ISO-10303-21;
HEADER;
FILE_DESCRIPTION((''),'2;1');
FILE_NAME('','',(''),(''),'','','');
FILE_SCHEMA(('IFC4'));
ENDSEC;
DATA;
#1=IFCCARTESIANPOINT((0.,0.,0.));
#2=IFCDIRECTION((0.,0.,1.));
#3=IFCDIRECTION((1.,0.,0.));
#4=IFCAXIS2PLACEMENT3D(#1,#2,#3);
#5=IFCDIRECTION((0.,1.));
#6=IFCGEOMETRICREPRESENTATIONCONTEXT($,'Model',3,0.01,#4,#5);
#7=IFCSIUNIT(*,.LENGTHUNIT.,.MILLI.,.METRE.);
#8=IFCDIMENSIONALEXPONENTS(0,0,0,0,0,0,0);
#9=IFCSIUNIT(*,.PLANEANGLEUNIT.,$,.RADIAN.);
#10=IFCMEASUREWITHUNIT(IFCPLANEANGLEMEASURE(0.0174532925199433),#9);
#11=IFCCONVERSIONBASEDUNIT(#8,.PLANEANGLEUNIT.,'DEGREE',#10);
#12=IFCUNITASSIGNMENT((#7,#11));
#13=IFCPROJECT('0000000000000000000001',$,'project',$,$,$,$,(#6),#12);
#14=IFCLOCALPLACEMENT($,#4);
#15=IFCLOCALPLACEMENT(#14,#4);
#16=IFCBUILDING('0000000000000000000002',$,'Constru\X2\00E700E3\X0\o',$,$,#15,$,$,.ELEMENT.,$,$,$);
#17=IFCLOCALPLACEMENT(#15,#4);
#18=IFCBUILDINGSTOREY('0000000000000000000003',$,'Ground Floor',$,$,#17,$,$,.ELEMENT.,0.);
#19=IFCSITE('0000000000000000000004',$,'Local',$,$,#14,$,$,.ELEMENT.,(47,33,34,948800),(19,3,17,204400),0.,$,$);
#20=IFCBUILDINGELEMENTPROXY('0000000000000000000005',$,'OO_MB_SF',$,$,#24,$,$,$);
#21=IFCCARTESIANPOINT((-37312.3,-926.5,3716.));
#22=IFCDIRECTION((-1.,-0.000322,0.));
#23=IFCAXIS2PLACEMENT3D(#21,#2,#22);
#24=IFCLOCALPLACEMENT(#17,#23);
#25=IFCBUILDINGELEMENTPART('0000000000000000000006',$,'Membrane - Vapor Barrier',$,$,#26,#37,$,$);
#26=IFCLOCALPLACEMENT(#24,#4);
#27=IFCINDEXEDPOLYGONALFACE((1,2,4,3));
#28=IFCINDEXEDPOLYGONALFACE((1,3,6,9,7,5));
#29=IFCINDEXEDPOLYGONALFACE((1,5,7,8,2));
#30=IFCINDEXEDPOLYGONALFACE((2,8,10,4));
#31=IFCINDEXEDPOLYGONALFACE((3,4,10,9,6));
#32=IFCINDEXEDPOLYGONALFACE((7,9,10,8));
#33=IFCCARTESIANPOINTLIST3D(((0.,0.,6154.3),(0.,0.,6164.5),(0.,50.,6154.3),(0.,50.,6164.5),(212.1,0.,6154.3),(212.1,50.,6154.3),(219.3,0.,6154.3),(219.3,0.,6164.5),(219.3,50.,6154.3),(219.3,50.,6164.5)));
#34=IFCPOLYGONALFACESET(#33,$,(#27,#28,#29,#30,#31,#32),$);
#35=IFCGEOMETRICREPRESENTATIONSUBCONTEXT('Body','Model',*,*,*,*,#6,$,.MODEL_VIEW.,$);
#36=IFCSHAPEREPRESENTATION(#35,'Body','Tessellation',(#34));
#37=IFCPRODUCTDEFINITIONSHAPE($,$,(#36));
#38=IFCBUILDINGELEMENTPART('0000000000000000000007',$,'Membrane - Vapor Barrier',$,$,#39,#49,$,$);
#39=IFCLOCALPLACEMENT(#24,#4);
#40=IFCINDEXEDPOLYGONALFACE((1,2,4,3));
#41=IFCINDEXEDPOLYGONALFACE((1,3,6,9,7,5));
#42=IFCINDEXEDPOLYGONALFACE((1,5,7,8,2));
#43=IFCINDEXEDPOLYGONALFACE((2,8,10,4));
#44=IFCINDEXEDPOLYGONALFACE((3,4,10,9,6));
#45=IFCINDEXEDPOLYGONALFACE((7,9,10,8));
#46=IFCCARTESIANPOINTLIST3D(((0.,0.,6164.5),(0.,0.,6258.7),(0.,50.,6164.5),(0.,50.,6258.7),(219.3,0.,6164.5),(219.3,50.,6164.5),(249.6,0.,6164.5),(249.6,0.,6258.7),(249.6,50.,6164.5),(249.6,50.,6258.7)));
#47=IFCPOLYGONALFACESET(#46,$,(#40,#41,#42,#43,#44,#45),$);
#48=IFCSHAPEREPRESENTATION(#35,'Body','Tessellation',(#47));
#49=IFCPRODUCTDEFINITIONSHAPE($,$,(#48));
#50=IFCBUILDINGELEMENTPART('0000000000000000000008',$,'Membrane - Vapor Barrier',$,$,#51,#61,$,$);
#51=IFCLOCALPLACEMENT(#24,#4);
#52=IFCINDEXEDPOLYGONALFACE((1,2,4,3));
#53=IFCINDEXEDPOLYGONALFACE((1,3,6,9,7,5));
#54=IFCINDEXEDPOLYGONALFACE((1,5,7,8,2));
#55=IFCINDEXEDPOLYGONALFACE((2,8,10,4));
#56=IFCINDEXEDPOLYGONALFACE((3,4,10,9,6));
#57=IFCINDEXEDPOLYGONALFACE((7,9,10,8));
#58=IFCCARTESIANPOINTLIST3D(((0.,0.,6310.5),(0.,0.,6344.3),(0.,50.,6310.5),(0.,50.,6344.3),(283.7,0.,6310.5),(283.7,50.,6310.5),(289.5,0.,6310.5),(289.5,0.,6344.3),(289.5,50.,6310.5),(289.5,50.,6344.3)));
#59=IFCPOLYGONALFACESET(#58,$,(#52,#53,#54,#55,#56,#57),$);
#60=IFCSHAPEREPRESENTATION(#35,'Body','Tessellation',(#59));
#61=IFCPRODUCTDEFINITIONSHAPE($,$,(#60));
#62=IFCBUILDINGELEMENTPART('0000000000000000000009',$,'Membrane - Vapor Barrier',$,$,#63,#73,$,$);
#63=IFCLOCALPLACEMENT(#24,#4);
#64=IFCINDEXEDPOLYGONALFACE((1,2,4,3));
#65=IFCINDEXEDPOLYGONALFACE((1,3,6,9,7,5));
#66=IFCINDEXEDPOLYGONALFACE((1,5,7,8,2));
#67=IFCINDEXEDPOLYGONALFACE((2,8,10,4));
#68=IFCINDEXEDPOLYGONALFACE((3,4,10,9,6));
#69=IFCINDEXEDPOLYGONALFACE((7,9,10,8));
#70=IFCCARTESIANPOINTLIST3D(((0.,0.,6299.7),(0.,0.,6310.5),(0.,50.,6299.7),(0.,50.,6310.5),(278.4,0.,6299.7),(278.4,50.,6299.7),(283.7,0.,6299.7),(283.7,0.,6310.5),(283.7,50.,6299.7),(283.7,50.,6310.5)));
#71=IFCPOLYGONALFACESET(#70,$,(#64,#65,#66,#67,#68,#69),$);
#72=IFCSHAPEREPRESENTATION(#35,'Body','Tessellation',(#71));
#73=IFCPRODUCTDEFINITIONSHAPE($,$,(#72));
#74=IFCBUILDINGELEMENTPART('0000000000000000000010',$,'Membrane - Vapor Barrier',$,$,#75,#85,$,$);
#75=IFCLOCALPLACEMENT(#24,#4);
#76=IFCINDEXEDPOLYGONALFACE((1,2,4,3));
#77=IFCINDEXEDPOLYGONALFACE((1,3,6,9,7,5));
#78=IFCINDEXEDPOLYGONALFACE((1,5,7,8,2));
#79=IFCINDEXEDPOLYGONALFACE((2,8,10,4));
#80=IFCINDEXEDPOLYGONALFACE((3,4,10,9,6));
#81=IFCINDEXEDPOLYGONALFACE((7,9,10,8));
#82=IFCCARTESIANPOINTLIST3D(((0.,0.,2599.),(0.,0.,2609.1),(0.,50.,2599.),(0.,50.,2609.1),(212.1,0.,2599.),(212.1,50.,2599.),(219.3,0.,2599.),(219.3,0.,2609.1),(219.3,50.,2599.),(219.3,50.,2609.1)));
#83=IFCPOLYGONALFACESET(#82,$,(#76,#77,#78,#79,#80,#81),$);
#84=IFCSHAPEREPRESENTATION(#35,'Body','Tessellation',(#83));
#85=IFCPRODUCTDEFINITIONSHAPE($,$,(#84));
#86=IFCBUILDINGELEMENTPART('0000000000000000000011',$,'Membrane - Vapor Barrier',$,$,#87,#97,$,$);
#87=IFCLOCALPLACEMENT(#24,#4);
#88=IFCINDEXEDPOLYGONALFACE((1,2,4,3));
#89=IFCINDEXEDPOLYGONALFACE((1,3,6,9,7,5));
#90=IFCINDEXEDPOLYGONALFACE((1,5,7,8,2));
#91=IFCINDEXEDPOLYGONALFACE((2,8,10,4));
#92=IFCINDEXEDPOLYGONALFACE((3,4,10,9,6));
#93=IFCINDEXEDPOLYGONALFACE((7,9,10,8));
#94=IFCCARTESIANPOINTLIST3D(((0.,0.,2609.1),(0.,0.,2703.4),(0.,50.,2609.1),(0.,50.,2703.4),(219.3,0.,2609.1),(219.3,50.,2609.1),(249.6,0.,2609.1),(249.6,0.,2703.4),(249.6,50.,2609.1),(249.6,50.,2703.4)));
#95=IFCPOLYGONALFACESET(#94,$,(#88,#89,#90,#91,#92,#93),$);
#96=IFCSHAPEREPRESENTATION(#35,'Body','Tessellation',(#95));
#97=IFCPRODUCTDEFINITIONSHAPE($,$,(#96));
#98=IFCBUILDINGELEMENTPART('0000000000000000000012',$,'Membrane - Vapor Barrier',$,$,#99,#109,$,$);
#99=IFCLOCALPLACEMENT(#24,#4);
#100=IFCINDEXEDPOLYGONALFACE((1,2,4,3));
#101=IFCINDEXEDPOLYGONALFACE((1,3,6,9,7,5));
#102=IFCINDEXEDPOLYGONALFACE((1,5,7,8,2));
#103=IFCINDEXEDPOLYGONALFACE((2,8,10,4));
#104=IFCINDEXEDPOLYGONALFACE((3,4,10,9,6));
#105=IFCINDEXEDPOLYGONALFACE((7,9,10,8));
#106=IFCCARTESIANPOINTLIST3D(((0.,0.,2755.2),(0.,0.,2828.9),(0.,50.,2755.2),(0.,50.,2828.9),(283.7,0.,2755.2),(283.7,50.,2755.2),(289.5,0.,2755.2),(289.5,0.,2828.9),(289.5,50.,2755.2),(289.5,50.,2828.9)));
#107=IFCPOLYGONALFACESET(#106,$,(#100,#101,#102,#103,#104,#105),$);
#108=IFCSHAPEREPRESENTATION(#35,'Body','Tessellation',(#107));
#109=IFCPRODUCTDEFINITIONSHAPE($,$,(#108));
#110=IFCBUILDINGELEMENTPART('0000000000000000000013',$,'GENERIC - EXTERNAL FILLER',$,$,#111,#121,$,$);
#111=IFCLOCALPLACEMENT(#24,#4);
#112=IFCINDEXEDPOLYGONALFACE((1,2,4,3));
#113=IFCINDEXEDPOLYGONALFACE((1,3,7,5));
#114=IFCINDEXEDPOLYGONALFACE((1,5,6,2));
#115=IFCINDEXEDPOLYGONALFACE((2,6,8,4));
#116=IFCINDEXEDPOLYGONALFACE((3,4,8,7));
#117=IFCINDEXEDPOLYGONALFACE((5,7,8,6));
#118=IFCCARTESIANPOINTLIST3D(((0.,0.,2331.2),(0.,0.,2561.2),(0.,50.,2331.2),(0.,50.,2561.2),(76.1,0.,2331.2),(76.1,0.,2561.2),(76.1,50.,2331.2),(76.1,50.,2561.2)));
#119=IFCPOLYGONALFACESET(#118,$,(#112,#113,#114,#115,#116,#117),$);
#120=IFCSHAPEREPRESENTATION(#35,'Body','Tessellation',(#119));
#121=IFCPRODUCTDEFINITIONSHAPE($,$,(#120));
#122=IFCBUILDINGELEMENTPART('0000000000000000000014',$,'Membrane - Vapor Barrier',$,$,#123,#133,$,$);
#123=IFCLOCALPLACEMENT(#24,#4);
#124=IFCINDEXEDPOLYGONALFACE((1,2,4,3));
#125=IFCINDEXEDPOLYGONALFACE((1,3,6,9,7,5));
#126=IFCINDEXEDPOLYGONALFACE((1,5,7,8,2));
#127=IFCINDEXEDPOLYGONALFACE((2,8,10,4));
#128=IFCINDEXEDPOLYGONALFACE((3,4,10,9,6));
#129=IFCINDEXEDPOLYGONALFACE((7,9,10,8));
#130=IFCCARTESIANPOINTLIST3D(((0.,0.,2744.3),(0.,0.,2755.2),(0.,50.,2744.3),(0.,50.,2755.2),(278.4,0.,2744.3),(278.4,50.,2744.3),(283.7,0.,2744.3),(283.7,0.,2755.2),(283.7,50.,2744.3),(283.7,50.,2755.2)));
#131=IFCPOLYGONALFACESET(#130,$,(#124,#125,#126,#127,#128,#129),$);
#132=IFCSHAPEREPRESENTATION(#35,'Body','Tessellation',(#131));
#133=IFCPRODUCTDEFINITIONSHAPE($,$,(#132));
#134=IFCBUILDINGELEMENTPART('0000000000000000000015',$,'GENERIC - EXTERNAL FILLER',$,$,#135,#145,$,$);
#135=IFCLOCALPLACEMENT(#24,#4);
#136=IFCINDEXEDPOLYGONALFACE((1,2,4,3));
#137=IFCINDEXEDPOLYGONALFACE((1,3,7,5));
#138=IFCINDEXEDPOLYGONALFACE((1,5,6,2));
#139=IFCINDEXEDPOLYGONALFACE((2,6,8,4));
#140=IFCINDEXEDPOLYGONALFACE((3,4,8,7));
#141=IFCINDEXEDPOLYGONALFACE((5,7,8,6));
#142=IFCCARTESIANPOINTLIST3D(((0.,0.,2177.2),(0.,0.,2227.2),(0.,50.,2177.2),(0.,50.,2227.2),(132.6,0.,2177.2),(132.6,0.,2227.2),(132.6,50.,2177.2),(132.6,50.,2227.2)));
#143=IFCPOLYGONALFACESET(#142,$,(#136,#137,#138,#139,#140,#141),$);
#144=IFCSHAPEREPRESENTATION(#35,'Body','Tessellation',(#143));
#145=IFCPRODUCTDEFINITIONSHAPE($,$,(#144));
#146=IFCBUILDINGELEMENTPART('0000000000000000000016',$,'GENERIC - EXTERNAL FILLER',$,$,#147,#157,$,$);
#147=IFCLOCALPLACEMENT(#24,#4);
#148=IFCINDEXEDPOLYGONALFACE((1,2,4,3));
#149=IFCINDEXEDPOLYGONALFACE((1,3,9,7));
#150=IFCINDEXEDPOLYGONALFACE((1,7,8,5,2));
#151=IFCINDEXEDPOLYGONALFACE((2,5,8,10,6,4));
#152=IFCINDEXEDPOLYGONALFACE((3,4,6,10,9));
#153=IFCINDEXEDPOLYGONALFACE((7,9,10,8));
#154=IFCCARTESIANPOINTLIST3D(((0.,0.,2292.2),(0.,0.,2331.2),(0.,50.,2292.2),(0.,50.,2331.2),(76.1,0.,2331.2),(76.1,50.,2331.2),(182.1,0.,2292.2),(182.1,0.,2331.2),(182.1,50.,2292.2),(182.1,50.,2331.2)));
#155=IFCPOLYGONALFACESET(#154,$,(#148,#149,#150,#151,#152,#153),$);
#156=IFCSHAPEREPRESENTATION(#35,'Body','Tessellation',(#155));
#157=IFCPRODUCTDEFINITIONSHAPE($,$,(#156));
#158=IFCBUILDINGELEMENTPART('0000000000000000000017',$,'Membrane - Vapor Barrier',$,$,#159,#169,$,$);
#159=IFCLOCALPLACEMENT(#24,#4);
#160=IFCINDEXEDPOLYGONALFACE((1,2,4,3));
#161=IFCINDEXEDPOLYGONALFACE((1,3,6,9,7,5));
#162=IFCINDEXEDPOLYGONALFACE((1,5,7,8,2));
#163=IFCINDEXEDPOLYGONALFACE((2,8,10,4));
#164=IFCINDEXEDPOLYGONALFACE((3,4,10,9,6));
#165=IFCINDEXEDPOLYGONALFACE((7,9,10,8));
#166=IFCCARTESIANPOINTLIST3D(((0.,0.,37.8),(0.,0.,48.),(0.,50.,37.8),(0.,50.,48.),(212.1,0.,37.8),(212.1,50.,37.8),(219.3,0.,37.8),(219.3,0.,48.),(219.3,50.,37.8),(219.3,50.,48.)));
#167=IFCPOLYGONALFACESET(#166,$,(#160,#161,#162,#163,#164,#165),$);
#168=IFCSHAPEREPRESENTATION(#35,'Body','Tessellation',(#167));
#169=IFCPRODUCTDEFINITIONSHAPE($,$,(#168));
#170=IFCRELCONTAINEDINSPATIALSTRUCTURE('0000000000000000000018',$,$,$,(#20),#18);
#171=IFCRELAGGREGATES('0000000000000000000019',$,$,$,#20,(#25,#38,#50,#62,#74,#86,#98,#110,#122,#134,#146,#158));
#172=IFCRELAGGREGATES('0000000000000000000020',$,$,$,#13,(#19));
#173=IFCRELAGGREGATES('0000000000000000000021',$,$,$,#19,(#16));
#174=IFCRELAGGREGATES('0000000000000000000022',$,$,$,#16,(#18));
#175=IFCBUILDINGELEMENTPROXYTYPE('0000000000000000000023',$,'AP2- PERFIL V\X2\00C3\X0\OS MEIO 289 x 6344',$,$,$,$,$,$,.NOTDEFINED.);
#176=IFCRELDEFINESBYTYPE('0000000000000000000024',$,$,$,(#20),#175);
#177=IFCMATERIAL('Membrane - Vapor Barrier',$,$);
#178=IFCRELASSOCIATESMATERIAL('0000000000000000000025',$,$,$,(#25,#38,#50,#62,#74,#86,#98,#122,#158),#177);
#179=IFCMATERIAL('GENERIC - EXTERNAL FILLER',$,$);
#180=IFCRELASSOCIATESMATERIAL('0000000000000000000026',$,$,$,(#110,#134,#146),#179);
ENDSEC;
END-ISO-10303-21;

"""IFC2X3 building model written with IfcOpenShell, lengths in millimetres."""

from ifc_helpers import new_model, entity, si_unit, converted_unit, direction, frame, origin_with_axes, place, context, subcontext, project, spatial, polyline, outline, extrude, material, type_object, element, aggregate, save


model = new_model("IFC2X3")

# Units and contexts
model_context = context("Model", 3, precision=0.01, world=origin_with_axes(), true_north=direction((0.0, 1.0)))
body_context = subcontext(model_context, "Body", "Model", "MODEL_VIEW")
ifc_project = project(units=[si_unit("LENGTHUNIT", "METRE", prefix="MILLI"), converted_unit("PLANEANGLEUNIT", "DEGREE", entity("IfcPlaneAngleMeasure", 0.0174532925199433), si_unit("PLANEANGLEUNIT", "RADIAN"), dimensions=[0, 0, 0, 0, 0, 0, 0])], contexts=[model_context])

# Site, building, storey
site_placement = place(None, origin_with_axes())
site = spatial("IfcSite", under=ifc_project, at=site_placement, Name="Local", CompositionType="ELEMENT", RefLatitude=(47, 33, 34, 948800), RefLongitude=(19, 3, 17, 204400), RefElevation=0.0)
building_placement = place(site_placement, origin_with_axes())
building = spatial("IfcBuilding", under=site, at=building_placement, Name="Construção", CompositionType="ELEMENT")
storey_placement = place(building_placement, origin_with_axes())
storey = spatial("IfcBuildingStorey", under=building, at=storey_placement, Name="Ground Floor", CompositionType="ELEMENT", Elevation=0.0)

# Shared definitions
building_element_proxy_type = type_object("IfcBuildingElementProxyType", Name="AP2- PERFIL VÃOS MEIO 289 x 6344", PredefinedType="NOTDEFINED")
ifc_material_1 = material(Name="Membrane - Vapor Barrier")

# Building element proxy, building element parts
proxy_1_placement = place(storey_placement, frame((-37312.3, -926.5, 3716.0), z_axis=(0.0, 0.0, 1.0), x_axis=(-1.0, -0.000322, 0.0)))
proxy_1 = element("IfcBuildingElementProxy", 1, at=proxy_1_placement, inside=storey, type_object=building_element_proxy_type, Name="OO_MB_SF")
building_element_part_1_placement = place(proxy_1_placement, origin_with_axes())
building_element_part_1 = element("IfcBuildingElementPart", 2, at=building_element_part_1_placement, material=ifc_material_1, Name="Membrane - Vapor Barrier", context=body_context, shape_type="SweptSolid", body=[
    extrude(outline(polyline([(0.0, 6154.3), (212.1, 6154.3), (219.3, 6154.3), (219.3, 6164.5), (0.0, 6164.5), (0.0, 6154.3)])), frame((0.0, 50.0, 0.0), z_axis=(0.0, -1.0, 0.0), x_axis=(1.0, 0.0, 0.0)), (0.0, 0.0, 1.0), 50.0),
])
building_element_part_2_placement = place(proxy_1_placement, origin_with_axes())
building_element_part_2 = element("IfcBuildingElementPart", 3, at=building_element_part_2_placement, material=ifc_material_1, Name="Membrane - Vapor Barrier", context=body_context, shape_type="SweptSolid", body=[
    extrude(outline(polyline([(249.6, 6258.7), (0.0, 6258.7), (0.0, 6164.5), (219.3, 6164.5), (249.6, 6164.5), (249.6, 6258.7)])), frame((0.0, 50.0, 0.0), z_axis=(0.0, -1.0, 0.0), x_axis=(1.0, 0.0, 0.0)), (0.0, 0.0, 1.0), 50.0),
])
building_element_part_3_placement = place(proxy_1_placement, origin_with_axes())
building_element_part_3 = element("IfcBuildingElementPart", 4, at=building_element_part_3_placement, material=ifc_material_1, Name="Membrane - Vapor Barrier", context=body_context, shape_type="SweptSolid", body=[
    extrude(outline(polyline([(0.0, 6310.5), (283.7, 6310.5), (289.5, 6310.5), (289.5, 6344.3), (0.0, 6344.3), (0.0, 6310.5)])), frame((0.0, 50.0, 0.0), z_axis=(0.0, -1.0, 0.0), x_axis=(1.0, 0.0, 0.0)), (0.0, 0.0, 1.0), 50.0),
])
building_element_part_4_placement = place(proxy_1_placement, origin_with_axes())
building_element_part_4 = element("IfcBuildingElementPart", 5, at=building_element_part_4_placement, material=ifc_material_1, Name="Membrane - Vapor Barrier", context=body_context, shape_type="SweptSolid", body=[
    extrude(outline(polyline([(0.0, 6299.7), (278.4, 6299.7), (283.7, 6299.7), (283.7, 6310.5), (0.0, 6310.5), (0.0, 6299.7)])), frame((0.0, 50.0, 0.0), z_axis=(0.0, -1.0, 0.0), x_axis=(1.0, 0.0, 0.0)), (0.0, 0.0, 1.0), 50.0),
])
building_element_part_5_placement = place(proxy_1_placement, origin_with_axes())
building_element_part_5 = element("IfcBuildingElementPart", 6, at=building_element_part_5_placement, material=ifc_material_1, Name="Membrane - Vapor Barrier", context=body_context, shape_type="SweptSolid", body=[
    extrude(outline(polyline([(0.0, 2599.0), (212.1, 2599.0), (219.3, 2599.0), (219.3, 2609.1), (0.0, 2609.1), (0.0, 2599.0)])), frame((0.0, 50.0, 0.0), z_axis=(0.0, -1.0, 0.0), x_axis=(1.0, 0.0, 0.0)), (0.0, 0.0, 1.0), 50.0),
])
building_element_part_6_placement = place(proxy_1_placement, origin_with_axes())
building_element_part_6 = element("IfcBuildingElementPart", 7, at=building_element_part_6_placement, material=ifc_material_1, Name="Membrane - Vapor Barrier", context=body_context, shape_type="SweptSolid", body=[
    extrude(outline(polyline([(249.6, 2703.4), (0.0, 2703.4), (0.0, 2609.1), (219.3, 2609.1), (249.6, 2609.1), (249.6, 2703.4)])), frame((0.0, 50.0, 0.0), z_axis=(0.0, -1.0, 0.0), x_axis=(1.0, 0.0, 0.0)), (0.0, 0.0, 1.0), 50.0),
])
building_element_part_7_placement = place(proxy_1_placement, origin_with_axes())
building_element_part_7 = element("IfcBuildingElementPart", 8, at=building_element_part_7_placement, material=ifc_material_1, Name="Membrane - Vapor Barrier", context=body_context, shape_type="SweptSolid", body=[
    extrude(outline(polyline([(0.0, 2755.2), (283.7, 2755.2), (289.5, 2755.2), (289.5, 2828.9), (0.0, 2828.9), (0.0, 2755.2)])), frame((0.0, 50.0, 0.0), z_axis=(0.0, -1.0, 0.0), x_axis=(1.0, 0.0, 0.0)), (0.0, 0.0, 1.0), 50.0),
])
ifc_material_2 = material(Name="GENERIC - EXTERNAL FILLER")
building_element_part_8_placement = place(proxy_1_placement, origin_with_axes())
building_element_part_8 = element("IfcBuildingElementPart", 9, at=building_element_part_8_placement, material=ifc_material_2, Name="GENERIC - EXTERNAL FILLER", context=body_context, shape_type="SweptSolid", body=[
    extrude(outline(polyline([(76.1, 2561.2), (0.0, 2561.2), (0.0, 2331.2), (76.1, 2331.2), (76.1, 2561.2)])), frame((0.0, 50.0, 0.0), z_axis=(0.0, -1.0, 0.0), x_axis=(1.0, 0.0, 0.0)), (0.0, 0.0, 1.0), 50.0),
])
building_element_part_9_placement = place(proxy_1_placement, origin_with_axes())
building_element_part_9 = element("IfcBuildingElementPart", 10, at=building_element_part_9_placement, material=ifc_material_1, Name="Membrane - Vapor Barrier", context=body_context, shape_type="SweptSolid", body=[
    extrude(outline(polyline([(0.0, 2744.3), (278.4, 2744.3), (283.7, 2744.3), (283.7, 2755.2), (0.0, 2755.2), (0.0, 2744.3)])), frame((0.0, 50.0, 0.0), z_axis=(0.0, -1.0, 0.0), x_axis=(1.0, 0.0, 0.0)), (0.0, 0.0, 1.0), 50.0),
])
building_element_part_10_placement = place(proxy_1_placement, origin_with_axes())
building_element_part_10 = element("IfcBuildingElementPart", 11, at=building_element_part_10_placement, material=ifc_material_2, Name="GENERIC - EXTERNAL FILLER", context=body_context, shape_type="SweptSolid", body=[
    extrude(outline(polyline([(0.0, 2227.2), (0.0, 2177.2), (132.6, 2177.2), (132.6, 2227.2), (0.0, 2227.2)])), frame((0.0, 50.0, 0.0), z_axis=(0.0, -1.0, 0.0), x_axis=(1.0, 0.0, 0.0)), (0.0, 0.0, 1.0), 50.0),
])
building_element_part_11_placement = place(proxy_1_placement, origin_with_axes())
building_element_part_11 = element("IfcBuildingElementPart", 12, at=building_element_part_11_placement, material=ifc_material_2, Name="GENERIC - EXTERNAL FILLER", context=body_context, shape_type="SweptSolid", body=[
    extrude(outline(polyline([(0.0, 2331.2), (0.0, 2292.2), (182.1, 2292.2), (182.1, 2331.2), (76.1, 2331.2), (0.0, 2331.2)])), frame((0.0, 50.0, 0.0), z_axis=(0.0, -1.0, 0.0), x_axis=(1.0, 0.0, 0.0)), (0.0, 0.0, 1.0), 50.0),
])
building_element_part_12_placement = place(proxy_1_placement, origin_with_axes())
building_element_part_12 = element("IfcBuildingElementPart", 13, at=building_element_part_12_placement, material=ifc_material_1, Name="Membrane - Vapor Barrier", context=body_context, shape_type="SweptSolid", body=[
    extrude(outline(polyline([(0.0, 37.8), (212.1, 37.8), (219.3, 37.8), (219.3, 48.0), (0.0, 48.0), (0.0, 37.8)])), frame((0.0, 50.0, 0.0), z_axis=(0.0, -1.0, 0.0), x_axis=(1.0, 0.0, 0.0)), (0.0, 0.0, 1.0), 50.0),
])
aggregate(proxy_1, [building_element_part_1, building_element_part_2, building_element_part_3, building_element_part_4, building_element_part_5, building_element_part_6, building_element_part_7, building_element_part_8, building_element_part_9, building_element_part_10, building_element_part_11, building_element_part_12])

save(model, "model.ifc")
